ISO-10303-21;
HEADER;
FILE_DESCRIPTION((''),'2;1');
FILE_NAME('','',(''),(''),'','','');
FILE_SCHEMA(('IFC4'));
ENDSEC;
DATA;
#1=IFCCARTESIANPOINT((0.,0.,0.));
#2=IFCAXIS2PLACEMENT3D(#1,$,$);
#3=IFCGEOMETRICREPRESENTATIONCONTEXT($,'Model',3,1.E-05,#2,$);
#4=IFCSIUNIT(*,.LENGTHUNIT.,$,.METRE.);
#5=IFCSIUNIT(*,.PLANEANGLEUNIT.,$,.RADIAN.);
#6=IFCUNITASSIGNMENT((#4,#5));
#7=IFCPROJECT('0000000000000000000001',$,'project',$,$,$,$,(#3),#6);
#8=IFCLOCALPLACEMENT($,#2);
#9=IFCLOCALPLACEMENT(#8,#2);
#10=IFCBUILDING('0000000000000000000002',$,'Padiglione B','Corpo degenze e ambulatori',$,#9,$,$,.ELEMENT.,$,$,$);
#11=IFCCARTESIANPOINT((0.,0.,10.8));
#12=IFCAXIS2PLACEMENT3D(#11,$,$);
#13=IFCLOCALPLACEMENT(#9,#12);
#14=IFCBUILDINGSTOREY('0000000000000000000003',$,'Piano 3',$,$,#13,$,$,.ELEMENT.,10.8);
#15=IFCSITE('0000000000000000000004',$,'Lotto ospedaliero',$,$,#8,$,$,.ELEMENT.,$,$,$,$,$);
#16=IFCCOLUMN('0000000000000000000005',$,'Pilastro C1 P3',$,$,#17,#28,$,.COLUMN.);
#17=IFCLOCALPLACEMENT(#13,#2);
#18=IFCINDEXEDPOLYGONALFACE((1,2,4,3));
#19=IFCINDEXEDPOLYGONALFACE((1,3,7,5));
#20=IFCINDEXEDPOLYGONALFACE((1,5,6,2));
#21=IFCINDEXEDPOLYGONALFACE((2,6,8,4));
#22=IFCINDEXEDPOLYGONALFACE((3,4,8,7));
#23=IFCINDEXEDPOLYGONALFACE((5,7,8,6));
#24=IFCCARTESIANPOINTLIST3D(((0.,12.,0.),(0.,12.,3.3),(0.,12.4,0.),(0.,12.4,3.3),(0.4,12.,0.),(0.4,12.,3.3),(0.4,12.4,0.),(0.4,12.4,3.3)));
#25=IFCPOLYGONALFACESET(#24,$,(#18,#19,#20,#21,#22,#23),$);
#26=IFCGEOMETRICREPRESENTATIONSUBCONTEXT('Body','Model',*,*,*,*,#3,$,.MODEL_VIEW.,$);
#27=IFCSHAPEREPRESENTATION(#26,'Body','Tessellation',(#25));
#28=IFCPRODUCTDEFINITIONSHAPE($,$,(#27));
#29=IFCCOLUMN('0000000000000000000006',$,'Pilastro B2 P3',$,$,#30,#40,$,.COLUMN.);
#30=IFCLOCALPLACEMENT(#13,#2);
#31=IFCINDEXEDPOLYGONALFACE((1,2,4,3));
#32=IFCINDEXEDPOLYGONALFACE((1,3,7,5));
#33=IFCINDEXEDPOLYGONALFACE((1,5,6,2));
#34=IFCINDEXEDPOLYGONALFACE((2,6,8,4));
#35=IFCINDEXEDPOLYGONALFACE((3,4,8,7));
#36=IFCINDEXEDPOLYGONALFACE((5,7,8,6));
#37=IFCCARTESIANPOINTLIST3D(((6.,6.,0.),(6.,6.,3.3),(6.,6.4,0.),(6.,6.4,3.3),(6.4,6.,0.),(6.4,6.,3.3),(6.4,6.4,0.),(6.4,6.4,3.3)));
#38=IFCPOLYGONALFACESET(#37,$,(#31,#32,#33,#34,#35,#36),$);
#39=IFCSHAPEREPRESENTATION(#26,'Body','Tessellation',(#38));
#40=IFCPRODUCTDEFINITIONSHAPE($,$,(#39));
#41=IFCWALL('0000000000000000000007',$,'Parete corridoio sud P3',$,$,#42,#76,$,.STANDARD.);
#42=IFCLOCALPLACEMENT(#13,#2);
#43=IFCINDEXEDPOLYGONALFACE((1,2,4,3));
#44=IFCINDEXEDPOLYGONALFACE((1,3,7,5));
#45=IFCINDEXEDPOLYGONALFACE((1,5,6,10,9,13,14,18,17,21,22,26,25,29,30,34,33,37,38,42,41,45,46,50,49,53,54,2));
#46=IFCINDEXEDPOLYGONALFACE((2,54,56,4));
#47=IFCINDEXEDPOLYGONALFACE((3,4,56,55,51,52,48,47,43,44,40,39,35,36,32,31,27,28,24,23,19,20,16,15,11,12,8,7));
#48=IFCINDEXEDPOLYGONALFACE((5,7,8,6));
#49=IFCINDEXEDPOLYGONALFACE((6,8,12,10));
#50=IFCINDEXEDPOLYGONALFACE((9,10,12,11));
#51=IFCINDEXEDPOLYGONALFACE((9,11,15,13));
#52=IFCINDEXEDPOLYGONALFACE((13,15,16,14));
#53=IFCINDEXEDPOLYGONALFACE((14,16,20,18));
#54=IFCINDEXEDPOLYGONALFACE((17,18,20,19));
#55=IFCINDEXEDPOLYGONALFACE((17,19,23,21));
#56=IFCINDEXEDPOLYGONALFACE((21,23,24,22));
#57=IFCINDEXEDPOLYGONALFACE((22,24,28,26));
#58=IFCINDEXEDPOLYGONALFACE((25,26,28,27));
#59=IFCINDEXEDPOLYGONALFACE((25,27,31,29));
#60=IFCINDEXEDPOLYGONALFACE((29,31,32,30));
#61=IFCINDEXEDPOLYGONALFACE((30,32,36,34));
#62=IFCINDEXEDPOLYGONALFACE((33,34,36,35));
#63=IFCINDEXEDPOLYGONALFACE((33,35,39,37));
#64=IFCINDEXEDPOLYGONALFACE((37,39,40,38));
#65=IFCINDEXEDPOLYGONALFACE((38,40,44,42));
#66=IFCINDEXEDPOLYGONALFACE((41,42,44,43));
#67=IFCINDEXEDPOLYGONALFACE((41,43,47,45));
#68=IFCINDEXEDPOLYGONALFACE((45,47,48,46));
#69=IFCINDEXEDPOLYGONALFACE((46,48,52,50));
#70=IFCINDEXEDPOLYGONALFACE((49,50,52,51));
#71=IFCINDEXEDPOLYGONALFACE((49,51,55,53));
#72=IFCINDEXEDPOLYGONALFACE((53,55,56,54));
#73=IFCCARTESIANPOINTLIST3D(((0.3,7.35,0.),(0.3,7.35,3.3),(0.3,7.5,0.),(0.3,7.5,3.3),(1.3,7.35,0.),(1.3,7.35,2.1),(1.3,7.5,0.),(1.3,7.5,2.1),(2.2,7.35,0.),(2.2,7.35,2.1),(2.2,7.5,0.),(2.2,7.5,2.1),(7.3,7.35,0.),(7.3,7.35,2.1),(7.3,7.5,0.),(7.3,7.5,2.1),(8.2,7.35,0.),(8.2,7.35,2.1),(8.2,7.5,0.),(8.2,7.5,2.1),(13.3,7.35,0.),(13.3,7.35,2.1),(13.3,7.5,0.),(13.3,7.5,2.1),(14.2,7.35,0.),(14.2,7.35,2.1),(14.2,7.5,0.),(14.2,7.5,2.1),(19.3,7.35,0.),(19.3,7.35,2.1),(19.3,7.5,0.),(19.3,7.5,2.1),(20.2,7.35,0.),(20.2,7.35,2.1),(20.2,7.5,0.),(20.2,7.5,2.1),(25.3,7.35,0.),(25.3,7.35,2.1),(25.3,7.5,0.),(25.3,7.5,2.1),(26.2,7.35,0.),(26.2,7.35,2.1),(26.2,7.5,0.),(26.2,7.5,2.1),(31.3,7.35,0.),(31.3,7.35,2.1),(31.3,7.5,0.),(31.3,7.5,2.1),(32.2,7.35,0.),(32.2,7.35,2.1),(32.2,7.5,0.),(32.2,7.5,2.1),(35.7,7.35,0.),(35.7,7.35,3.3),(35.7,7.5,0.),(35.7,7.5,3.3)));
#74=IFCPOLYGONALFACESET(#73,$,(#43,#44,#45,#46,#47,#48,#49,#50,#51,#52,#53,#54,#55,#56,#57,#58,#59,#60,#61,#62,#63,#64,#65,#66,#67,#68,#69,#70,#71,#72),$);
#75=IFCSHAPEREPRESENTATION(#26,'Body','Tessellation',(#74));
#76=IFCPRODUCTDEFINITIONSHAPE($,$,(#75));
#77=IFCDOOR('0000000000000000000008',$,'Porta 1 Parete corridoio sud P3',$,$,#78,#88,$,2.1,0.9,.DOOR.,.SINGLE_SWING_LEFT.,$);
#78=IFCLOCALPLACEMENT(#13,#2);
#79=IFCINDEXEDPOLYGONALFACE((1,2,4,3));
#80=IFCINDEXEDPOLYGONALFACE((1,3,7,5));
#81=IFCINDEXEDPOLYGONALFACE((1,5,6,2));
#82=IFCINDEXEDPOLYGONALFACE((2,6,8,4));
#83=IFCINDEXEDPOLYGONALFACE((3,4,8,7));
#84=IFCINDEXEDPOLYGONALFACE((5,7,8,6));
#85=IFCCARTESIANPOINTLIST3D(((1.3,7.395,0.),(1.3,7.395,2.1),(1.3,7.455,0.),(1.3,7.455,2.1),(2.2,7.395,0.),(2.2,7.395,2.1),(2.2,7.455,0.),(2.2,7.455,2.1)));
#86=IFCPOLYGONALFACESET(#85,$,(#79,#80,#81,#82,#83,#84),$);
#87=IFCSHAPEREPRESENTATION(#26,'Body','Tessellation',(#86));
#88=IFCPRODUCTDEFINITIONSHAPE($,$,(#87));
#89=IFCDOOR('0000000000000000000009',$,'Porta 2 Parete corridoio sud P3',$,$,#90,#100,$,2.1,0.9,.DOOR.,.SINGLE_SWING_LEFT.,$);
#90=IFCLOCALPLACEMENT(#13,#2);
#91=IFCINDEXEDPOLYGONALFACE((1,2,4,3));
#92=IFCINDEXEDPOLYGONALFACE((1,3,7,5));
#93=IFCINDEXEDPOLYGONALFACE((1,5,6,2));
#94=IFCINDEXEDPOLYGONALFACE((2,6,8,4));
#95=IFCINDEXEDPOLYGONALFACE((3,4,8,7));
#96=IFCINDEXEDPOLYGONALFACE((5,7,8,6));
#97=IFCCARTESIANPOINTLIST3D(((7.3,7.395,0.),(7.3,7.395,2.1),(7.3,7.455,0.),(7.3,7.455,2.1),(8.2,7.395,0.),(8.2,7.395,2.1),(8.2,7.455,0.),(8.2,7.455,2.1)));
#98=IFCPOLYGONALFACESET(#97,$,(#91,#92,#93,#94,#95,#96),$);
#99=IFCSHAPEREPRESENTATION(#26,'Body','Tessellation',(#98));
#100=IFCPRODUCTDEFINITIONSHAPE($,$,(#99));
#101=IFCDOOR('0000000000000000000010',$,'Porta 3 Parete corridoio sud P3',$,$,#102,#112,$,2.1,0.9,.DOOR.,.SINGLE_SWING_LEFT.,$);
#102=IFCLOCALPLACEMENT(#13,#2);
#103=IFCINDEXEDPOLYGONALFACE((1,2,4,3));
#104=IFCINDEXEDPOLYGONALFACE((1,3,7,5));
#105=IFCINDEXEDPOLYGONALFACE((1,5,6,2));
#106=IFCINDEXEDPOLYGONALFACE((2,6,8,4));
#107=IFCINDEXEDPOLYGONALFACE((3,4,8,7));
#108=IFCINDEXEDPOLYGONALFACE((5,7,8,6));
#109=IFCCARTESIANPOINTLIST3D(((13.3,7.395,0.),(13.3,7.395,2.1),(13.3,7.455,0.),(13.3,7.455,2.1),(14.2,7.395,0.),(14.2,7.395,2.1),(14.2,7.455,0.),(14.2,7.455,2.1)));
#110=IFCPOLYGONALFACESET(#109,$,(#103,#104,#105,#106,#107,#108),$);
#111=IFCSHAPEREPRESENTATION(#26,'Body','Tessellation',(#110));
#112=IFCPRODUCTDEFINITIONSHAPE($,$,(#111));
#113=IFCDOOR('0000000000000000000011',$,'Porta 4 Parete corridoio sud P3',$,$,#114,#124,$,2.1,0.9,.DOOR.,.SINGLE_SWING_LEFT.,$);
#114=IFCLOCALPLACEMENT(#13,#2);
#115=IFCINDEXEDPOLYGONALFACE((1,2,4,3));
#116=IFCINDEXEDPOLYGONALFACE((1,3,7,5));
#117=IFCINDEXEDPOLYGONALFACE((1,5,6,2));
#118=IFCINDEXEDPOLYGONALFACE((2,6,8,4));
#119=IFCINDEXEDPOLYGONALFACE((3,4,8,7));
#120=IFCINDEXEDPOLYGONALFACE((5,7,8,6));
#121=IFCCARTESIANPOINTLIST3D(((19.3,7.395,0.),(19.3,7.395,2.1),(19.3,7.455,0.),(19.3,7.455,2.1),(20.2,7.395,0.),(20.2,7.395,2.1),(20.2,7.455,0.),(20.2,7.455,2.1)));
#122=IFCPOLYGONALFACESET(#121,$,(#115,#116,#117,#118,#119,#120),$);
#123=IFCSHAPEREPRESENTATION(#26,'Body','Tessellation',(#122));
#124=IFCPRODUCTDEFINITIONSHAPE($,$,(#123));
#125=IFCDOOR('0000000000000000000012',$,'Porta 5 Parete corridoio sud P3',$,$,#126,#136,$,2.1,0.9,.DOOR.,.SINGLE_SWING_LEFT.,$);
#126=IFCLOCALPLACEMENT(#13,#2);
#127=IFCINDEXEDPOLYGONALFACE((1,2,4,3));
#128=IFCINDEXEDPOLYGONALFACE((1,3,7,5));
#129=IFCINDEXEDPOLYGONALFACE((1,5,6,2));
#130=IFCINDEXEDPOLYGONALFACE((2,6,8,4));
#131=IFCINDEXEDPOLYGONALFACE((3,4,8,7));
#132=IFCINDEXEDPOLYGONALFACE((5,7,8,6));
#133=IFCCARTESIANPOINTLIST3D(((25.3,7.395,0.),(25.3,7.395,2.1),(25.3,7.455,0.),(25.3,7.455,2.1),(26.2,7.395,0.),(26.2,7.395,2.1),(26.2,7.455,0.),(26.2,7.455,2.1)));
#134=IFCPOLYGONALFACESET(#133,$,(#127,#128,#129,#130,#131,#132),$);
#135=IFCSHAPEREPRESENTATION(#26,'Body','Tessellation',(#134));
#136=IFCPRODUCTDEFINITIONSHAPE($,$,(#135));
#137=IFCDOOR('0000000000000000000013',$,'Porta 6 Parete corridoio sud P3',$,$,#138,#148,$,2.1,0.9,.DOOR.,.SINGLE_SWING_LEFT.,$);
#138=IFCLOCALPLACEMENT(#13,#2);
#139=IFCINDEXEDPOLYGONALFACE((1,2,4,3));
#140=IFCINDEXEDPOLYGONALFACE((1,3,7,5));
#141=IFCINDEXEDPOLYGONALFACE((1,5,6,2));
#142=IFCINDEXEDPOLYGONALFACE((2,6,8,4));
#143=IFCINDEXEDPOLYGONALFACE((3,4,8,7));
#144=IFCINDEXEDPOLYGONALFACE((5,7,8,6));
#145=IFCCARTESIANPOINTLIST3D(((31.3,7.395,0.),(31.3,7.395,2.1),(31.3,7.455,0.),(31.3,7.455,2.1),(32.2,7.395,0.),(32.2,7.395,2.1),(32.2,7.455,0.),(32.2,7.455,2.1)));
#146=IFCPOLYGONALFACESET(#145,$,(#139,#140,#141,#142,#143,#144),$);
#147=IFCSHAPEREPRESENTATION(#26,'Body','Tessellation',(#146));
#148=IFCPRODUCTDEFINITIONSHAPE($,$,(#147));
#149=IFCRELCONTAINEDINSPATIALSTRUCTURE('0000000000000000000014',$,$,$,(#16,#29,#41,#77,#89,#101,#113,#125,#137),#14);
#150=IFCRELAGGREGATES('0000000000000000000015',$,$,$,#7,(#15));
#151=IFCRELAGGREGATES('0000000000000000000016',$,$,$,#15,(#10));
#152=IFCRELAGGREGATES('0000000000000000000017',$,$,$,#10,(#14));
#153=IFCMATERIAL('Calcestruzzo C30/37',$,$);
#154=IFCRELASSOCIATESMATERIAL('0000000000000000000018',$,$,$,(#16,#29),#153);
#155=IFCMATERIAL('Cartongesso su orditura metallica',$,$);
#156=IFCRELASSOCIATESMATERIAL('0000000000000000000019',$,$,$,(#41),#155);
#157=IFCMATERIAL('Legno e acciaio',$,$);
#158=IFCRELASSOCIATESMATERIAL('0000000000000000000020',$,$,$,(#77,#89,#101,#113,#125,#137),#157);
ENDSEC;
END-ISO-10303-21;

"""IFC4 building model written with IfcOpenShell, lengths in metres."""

from ifc_helpers import new_model, si_unit, frame, frame_2d, origin, place, context, subcontext, project, spatial, rectangle, extrude, material, element, fill, save


model = new_model("IFC4")

# Units and contexts
model_context = context("Model", 3, precision=1e-05, world=origin())
body_context = subcontext(model_context, "Body", "Model", "MODEL_VIEW")
ifc_project = project(units=[si_unit("LENGTHUNIT", "METRE"), si_unit("PLANEANGLEUNIT", "RADIAN")], contexts=[model_context])

# Site, building, storey
site_placement = place(None, origin())
site = spatial("IfcSite", under=ifc_project, at=site_placement, Name="Lotto ospedaliero", CompositionType="ELEMENT")
building_placement = place(site_placement, origin())
building = spatial("IfcBuilding", under=site, at=building_placement, Name="Padiglione B", Description="Corpo degenze e ambulatori", CompositionType="ELEMENT")
storey_placement = place(building_placement, frame((0.0, 0.0, 10.8)))
storey = spatial("IfcBuildingStorey", under=building, at=storey_placement, Name="Piano 3", CompositionType="ELEMENT", Elevation=10.8)

# Columns
ifc_material_1 = material(Name="Calcestruzzo C30/37")
for number, where, name in (
    (1, (0.0, 12.0, 0.0), "Pilastro C1 P3"),
    (2, (6.0, 6.0, 0.0), "Pilastro B2 P3"),
):
    element("IfcColumn", number, at=place(storey_placement, frame(where)), inside=storey, material=ifc_material_1, Name=name, PredefinedType="COLUMN", context=body_context, shape_type="SweptSolid", body=[
        extrude(rectangle(XDim=0.4, YDim=0.4, at=frame_2d((0.2, 0.2))), origin(), (0.0, 0.0, 1.0), 3.3),
    ])

# Wall, openings, doors
ifc_material_2 = material(Name="Cartongesso su orditura metallica")
wall_1_placement = place(storey_placement, frame((0.3, 7.35, 0.0)))
wall_1 = element("IfcWall", 3, at=wall_1_placement, inside=storey, material=ifc_material_2, Name="Parete corridoio sud P3", PredefinedType="STANDARD", context=body_context, shape_type="SweptSolid", body=[
    extrude(rectangle(XDim=35.4, YDim=0.15, at=frame_2d((17.7, 0.075))), origin(), (0.0, 0.0, 1.0), 3.3),
])
opening_1_placement = place(wall_1_placement, frame((1.0, -0.1, 0.0)))
opening_1 = element("IfcOpeningElement", 4, at=opening_1_placement, cuts=wall_1, PredefinedType="OPENING", context=body_context, shape_type="SweptSolid", body=[
    extrude(rectangle(XDim=0.9, YDim=0.35, at=frame_2d((0.45, 0.175))), origin(), (0.0, 0.0, 1.0), 2.1),
])
opening_2_placement = place(wall_1_placement, frame((7.0, -0.1, 0.0)))
opening_2 = element("IfcOpeningElement", 5, at=opening_2_placement, cuts=wall_1, PredefinedType="OPENING", context=body_context, shape_type="SweptSolid", body=[
    extrude(rectangle(XDim=0.9, YDim=0.35, at=frame_2d((0.45, 0.175))), origin(), (0.0, 0.0, 1.0), 2.1),
])
opening_3_placement = place(wall_1_placement, frame((13.0, -0.1, 0.0)))
opening_3 = element("IfcOpeningElement", 6, at=opening_3_placement, cuts=wall_1, PredefinedType="OPENING", context=body_context, shape_type="SweptSolid", body=[
    extrude(rectangle(XDim=0.9, YDim=0.35, at=frame_2d((0.45, 0.175))), origin(), (0.0, 0.0, 1.0), 2.1),
])
opening_4_placement = place(wall_1_placement, frame((19.0, -0.1, 0.0)))
opening_4 = element("IfcOpeningElement", 7, at=opening_4_placement, cuts=wall_1, PredefinedType="OPENING", context=body_context, shape_type="SweptSolid", body=[
    extrude(rectangle(XDim=0.9, YDim=0.35, at=frame_2d((0.45, 0.175))), origin(), (0.0, 0.0, 1.0), 2.1),
])
opening_5_placement = place(wall_1_placement, frame((25.0, -0.1, 0.0)))
opening_5 = element("IfcOpeningElement", 8, at=opening_5_placement, cuts=wall_1, PredefinedType="OPENING", context=body_context, shape_type="SweptSolid", body=[
    extrude(rectangle(XDim=0.9, YDim=0.35, at=frame_2d((0.45, 0.175))), origin(), (0.0, 0.0, 1.0), 2.1),
])
opening_6_placement = place(wall_1_placement, frame((31.0, -0.1, 0.0)))
opening_6 = element("IfcOpeningElement", 9, at=opening_6_placement, cuts=wall_1, PredefinedType="OPENING", context=body_context, shape_type="SweptSolid", body=[
    extrude(rectangle(XDim=0.9, YDim=0.35, at=frame_2d((0.45, 0.175))), origin(), (0.0, 0.0, 1.0), 2.1),
])
ifc_material_3 = material(Name="Legno e acciaio")
door_1_placement = place(wall_1_placement, frame((1.0, 0.045, 0.0)))
door_1 = element("IfcDoor", 10, at=door_1_placement, inside=storey, material=ifc_material_3, Name="Porta 1 Parete corridoio sud P3", OperationType="SINGLE_SWING_LEFT", OverallHeight=2.1, OverallWidth=0.9, PredefinedType="DOOR", context=body_context, shape_type="SweptSolid", body=[
    extrude(rectangle(XDim=0.9, YDim=0.06, at=frame_2d((0.45, 0.03))), origin(), (0.0, 0.0, 1.0), 2.1),
])
fill(opening_1, door_1)
door_2_placement = place(wall_1_placement, frame((7.0, 0.045, 0.0)))
door_2 = element("IfcDoor", 11, at=door_2_placement, inside=storey, material=ifc_material_3, Name="Porta 2 Parete corridoio sud P3", OperationType="SINGLE_SWING_LEFT", OverallHeight=2.1, OverallWidth=0.9, PredefinedType="DOOR", context=body_context, shape_type="SweptSolid", body=[
    extrude(rectangle(XDim=0.9, YDim=0.06, at=frame_2d((0.45, 0.03))), origin(), (0.0, 0.0, 1.0), 2.1),
])
fill(opening_2, door_2)
door_3_placement = place(wall_1_placement, frame((13.0, 0.045, 0.0)))
door_3 = element("IfcDoor", 12, at=door_3_placement, inside=storey, material=ifc_material_3, Name="Porta 3 Parete corridoio sud P3", OperationType="SINGLE_SWING_LEFT", OverallHeight=2.1, OverallWidth=0.9, PredefinedType="DOOR", context=body_context, shape_type="SweptSolid", body=[
    extrude(rectangle(XDim=0.9, YDim=0.06, at=frame_2d((0.45, 0.03))), origin(), (0.0, 0.0, 1.0), 2.1),
])
fill(opening_3, door_3)
door_4_placement = place(wall_1_placement, frame((19.0, 0.045, 0.0)))
door_4 = element("IfcDoor", 13, at=door_4_placement, inside=storey, material=ifc_material_3, Name="Porta 4 Parete corridoio sud P3", OperationType="SINGLE_SWING_LEFT", OverallHeight=2.1, OverallWidth=0.9, PredefinedType="DOOR", context=body_context, shape_type="SweptSolid", body=[
    extrude(rectangle(XDim=0.9, YDim=0.06, at=frame_2d((0.45, 0.03))), origin(), (0.0, 0.0, 1.0), 2.1),
])
fill(opening_4, door_4)
door_5_placement = place(wall_1_placement, frame((25.0, 0.045, 0.0)))
door_5 = element("IfcDoor", 14, at=door_5_placement, inside=storey, material=ifc_material_3, Name="Porta 5 Parete corridoio sud P3", OperationType="SINGLE_SWING_LEFT", OverallHeight=2.1, OverallWidth=0.9, PredefinedType="DOOR", context=body_context, shape_type="SweptSolid", body=[
    extrude(rectangle(XDim=0.9, YDim=0.06, at=frame_2d((0.45, 0.03))), origin(), (0.0, 0.0, 1.0), 2.1),
])
fill(opening_5, door_5)
door_6_placement = place(wall_1_placement, frame((31.0, 0.045, 0.0)))
door_6 = element("IfcDoor", 15, at=door_6_placement, inside=storey, material=ifc_material_3, Name="Porta 6 Parete corridoio sud P3", OperationType="SINGLE_SWING_LEFT", OverallHeight=2.1, OverallWidth=0.9, PredefinedType="DOOR", context=body_context, shape_type="SweptSolid", body=[
    extrude(rectangle(XDim=0.9, YDim=0.06, at=frame_2d((0.45, 0.03))), origin(), (0.0, 0.0, 1.0), 2.1),
])
fill(opening_6, door_6)

save(model, "model.ifc")
